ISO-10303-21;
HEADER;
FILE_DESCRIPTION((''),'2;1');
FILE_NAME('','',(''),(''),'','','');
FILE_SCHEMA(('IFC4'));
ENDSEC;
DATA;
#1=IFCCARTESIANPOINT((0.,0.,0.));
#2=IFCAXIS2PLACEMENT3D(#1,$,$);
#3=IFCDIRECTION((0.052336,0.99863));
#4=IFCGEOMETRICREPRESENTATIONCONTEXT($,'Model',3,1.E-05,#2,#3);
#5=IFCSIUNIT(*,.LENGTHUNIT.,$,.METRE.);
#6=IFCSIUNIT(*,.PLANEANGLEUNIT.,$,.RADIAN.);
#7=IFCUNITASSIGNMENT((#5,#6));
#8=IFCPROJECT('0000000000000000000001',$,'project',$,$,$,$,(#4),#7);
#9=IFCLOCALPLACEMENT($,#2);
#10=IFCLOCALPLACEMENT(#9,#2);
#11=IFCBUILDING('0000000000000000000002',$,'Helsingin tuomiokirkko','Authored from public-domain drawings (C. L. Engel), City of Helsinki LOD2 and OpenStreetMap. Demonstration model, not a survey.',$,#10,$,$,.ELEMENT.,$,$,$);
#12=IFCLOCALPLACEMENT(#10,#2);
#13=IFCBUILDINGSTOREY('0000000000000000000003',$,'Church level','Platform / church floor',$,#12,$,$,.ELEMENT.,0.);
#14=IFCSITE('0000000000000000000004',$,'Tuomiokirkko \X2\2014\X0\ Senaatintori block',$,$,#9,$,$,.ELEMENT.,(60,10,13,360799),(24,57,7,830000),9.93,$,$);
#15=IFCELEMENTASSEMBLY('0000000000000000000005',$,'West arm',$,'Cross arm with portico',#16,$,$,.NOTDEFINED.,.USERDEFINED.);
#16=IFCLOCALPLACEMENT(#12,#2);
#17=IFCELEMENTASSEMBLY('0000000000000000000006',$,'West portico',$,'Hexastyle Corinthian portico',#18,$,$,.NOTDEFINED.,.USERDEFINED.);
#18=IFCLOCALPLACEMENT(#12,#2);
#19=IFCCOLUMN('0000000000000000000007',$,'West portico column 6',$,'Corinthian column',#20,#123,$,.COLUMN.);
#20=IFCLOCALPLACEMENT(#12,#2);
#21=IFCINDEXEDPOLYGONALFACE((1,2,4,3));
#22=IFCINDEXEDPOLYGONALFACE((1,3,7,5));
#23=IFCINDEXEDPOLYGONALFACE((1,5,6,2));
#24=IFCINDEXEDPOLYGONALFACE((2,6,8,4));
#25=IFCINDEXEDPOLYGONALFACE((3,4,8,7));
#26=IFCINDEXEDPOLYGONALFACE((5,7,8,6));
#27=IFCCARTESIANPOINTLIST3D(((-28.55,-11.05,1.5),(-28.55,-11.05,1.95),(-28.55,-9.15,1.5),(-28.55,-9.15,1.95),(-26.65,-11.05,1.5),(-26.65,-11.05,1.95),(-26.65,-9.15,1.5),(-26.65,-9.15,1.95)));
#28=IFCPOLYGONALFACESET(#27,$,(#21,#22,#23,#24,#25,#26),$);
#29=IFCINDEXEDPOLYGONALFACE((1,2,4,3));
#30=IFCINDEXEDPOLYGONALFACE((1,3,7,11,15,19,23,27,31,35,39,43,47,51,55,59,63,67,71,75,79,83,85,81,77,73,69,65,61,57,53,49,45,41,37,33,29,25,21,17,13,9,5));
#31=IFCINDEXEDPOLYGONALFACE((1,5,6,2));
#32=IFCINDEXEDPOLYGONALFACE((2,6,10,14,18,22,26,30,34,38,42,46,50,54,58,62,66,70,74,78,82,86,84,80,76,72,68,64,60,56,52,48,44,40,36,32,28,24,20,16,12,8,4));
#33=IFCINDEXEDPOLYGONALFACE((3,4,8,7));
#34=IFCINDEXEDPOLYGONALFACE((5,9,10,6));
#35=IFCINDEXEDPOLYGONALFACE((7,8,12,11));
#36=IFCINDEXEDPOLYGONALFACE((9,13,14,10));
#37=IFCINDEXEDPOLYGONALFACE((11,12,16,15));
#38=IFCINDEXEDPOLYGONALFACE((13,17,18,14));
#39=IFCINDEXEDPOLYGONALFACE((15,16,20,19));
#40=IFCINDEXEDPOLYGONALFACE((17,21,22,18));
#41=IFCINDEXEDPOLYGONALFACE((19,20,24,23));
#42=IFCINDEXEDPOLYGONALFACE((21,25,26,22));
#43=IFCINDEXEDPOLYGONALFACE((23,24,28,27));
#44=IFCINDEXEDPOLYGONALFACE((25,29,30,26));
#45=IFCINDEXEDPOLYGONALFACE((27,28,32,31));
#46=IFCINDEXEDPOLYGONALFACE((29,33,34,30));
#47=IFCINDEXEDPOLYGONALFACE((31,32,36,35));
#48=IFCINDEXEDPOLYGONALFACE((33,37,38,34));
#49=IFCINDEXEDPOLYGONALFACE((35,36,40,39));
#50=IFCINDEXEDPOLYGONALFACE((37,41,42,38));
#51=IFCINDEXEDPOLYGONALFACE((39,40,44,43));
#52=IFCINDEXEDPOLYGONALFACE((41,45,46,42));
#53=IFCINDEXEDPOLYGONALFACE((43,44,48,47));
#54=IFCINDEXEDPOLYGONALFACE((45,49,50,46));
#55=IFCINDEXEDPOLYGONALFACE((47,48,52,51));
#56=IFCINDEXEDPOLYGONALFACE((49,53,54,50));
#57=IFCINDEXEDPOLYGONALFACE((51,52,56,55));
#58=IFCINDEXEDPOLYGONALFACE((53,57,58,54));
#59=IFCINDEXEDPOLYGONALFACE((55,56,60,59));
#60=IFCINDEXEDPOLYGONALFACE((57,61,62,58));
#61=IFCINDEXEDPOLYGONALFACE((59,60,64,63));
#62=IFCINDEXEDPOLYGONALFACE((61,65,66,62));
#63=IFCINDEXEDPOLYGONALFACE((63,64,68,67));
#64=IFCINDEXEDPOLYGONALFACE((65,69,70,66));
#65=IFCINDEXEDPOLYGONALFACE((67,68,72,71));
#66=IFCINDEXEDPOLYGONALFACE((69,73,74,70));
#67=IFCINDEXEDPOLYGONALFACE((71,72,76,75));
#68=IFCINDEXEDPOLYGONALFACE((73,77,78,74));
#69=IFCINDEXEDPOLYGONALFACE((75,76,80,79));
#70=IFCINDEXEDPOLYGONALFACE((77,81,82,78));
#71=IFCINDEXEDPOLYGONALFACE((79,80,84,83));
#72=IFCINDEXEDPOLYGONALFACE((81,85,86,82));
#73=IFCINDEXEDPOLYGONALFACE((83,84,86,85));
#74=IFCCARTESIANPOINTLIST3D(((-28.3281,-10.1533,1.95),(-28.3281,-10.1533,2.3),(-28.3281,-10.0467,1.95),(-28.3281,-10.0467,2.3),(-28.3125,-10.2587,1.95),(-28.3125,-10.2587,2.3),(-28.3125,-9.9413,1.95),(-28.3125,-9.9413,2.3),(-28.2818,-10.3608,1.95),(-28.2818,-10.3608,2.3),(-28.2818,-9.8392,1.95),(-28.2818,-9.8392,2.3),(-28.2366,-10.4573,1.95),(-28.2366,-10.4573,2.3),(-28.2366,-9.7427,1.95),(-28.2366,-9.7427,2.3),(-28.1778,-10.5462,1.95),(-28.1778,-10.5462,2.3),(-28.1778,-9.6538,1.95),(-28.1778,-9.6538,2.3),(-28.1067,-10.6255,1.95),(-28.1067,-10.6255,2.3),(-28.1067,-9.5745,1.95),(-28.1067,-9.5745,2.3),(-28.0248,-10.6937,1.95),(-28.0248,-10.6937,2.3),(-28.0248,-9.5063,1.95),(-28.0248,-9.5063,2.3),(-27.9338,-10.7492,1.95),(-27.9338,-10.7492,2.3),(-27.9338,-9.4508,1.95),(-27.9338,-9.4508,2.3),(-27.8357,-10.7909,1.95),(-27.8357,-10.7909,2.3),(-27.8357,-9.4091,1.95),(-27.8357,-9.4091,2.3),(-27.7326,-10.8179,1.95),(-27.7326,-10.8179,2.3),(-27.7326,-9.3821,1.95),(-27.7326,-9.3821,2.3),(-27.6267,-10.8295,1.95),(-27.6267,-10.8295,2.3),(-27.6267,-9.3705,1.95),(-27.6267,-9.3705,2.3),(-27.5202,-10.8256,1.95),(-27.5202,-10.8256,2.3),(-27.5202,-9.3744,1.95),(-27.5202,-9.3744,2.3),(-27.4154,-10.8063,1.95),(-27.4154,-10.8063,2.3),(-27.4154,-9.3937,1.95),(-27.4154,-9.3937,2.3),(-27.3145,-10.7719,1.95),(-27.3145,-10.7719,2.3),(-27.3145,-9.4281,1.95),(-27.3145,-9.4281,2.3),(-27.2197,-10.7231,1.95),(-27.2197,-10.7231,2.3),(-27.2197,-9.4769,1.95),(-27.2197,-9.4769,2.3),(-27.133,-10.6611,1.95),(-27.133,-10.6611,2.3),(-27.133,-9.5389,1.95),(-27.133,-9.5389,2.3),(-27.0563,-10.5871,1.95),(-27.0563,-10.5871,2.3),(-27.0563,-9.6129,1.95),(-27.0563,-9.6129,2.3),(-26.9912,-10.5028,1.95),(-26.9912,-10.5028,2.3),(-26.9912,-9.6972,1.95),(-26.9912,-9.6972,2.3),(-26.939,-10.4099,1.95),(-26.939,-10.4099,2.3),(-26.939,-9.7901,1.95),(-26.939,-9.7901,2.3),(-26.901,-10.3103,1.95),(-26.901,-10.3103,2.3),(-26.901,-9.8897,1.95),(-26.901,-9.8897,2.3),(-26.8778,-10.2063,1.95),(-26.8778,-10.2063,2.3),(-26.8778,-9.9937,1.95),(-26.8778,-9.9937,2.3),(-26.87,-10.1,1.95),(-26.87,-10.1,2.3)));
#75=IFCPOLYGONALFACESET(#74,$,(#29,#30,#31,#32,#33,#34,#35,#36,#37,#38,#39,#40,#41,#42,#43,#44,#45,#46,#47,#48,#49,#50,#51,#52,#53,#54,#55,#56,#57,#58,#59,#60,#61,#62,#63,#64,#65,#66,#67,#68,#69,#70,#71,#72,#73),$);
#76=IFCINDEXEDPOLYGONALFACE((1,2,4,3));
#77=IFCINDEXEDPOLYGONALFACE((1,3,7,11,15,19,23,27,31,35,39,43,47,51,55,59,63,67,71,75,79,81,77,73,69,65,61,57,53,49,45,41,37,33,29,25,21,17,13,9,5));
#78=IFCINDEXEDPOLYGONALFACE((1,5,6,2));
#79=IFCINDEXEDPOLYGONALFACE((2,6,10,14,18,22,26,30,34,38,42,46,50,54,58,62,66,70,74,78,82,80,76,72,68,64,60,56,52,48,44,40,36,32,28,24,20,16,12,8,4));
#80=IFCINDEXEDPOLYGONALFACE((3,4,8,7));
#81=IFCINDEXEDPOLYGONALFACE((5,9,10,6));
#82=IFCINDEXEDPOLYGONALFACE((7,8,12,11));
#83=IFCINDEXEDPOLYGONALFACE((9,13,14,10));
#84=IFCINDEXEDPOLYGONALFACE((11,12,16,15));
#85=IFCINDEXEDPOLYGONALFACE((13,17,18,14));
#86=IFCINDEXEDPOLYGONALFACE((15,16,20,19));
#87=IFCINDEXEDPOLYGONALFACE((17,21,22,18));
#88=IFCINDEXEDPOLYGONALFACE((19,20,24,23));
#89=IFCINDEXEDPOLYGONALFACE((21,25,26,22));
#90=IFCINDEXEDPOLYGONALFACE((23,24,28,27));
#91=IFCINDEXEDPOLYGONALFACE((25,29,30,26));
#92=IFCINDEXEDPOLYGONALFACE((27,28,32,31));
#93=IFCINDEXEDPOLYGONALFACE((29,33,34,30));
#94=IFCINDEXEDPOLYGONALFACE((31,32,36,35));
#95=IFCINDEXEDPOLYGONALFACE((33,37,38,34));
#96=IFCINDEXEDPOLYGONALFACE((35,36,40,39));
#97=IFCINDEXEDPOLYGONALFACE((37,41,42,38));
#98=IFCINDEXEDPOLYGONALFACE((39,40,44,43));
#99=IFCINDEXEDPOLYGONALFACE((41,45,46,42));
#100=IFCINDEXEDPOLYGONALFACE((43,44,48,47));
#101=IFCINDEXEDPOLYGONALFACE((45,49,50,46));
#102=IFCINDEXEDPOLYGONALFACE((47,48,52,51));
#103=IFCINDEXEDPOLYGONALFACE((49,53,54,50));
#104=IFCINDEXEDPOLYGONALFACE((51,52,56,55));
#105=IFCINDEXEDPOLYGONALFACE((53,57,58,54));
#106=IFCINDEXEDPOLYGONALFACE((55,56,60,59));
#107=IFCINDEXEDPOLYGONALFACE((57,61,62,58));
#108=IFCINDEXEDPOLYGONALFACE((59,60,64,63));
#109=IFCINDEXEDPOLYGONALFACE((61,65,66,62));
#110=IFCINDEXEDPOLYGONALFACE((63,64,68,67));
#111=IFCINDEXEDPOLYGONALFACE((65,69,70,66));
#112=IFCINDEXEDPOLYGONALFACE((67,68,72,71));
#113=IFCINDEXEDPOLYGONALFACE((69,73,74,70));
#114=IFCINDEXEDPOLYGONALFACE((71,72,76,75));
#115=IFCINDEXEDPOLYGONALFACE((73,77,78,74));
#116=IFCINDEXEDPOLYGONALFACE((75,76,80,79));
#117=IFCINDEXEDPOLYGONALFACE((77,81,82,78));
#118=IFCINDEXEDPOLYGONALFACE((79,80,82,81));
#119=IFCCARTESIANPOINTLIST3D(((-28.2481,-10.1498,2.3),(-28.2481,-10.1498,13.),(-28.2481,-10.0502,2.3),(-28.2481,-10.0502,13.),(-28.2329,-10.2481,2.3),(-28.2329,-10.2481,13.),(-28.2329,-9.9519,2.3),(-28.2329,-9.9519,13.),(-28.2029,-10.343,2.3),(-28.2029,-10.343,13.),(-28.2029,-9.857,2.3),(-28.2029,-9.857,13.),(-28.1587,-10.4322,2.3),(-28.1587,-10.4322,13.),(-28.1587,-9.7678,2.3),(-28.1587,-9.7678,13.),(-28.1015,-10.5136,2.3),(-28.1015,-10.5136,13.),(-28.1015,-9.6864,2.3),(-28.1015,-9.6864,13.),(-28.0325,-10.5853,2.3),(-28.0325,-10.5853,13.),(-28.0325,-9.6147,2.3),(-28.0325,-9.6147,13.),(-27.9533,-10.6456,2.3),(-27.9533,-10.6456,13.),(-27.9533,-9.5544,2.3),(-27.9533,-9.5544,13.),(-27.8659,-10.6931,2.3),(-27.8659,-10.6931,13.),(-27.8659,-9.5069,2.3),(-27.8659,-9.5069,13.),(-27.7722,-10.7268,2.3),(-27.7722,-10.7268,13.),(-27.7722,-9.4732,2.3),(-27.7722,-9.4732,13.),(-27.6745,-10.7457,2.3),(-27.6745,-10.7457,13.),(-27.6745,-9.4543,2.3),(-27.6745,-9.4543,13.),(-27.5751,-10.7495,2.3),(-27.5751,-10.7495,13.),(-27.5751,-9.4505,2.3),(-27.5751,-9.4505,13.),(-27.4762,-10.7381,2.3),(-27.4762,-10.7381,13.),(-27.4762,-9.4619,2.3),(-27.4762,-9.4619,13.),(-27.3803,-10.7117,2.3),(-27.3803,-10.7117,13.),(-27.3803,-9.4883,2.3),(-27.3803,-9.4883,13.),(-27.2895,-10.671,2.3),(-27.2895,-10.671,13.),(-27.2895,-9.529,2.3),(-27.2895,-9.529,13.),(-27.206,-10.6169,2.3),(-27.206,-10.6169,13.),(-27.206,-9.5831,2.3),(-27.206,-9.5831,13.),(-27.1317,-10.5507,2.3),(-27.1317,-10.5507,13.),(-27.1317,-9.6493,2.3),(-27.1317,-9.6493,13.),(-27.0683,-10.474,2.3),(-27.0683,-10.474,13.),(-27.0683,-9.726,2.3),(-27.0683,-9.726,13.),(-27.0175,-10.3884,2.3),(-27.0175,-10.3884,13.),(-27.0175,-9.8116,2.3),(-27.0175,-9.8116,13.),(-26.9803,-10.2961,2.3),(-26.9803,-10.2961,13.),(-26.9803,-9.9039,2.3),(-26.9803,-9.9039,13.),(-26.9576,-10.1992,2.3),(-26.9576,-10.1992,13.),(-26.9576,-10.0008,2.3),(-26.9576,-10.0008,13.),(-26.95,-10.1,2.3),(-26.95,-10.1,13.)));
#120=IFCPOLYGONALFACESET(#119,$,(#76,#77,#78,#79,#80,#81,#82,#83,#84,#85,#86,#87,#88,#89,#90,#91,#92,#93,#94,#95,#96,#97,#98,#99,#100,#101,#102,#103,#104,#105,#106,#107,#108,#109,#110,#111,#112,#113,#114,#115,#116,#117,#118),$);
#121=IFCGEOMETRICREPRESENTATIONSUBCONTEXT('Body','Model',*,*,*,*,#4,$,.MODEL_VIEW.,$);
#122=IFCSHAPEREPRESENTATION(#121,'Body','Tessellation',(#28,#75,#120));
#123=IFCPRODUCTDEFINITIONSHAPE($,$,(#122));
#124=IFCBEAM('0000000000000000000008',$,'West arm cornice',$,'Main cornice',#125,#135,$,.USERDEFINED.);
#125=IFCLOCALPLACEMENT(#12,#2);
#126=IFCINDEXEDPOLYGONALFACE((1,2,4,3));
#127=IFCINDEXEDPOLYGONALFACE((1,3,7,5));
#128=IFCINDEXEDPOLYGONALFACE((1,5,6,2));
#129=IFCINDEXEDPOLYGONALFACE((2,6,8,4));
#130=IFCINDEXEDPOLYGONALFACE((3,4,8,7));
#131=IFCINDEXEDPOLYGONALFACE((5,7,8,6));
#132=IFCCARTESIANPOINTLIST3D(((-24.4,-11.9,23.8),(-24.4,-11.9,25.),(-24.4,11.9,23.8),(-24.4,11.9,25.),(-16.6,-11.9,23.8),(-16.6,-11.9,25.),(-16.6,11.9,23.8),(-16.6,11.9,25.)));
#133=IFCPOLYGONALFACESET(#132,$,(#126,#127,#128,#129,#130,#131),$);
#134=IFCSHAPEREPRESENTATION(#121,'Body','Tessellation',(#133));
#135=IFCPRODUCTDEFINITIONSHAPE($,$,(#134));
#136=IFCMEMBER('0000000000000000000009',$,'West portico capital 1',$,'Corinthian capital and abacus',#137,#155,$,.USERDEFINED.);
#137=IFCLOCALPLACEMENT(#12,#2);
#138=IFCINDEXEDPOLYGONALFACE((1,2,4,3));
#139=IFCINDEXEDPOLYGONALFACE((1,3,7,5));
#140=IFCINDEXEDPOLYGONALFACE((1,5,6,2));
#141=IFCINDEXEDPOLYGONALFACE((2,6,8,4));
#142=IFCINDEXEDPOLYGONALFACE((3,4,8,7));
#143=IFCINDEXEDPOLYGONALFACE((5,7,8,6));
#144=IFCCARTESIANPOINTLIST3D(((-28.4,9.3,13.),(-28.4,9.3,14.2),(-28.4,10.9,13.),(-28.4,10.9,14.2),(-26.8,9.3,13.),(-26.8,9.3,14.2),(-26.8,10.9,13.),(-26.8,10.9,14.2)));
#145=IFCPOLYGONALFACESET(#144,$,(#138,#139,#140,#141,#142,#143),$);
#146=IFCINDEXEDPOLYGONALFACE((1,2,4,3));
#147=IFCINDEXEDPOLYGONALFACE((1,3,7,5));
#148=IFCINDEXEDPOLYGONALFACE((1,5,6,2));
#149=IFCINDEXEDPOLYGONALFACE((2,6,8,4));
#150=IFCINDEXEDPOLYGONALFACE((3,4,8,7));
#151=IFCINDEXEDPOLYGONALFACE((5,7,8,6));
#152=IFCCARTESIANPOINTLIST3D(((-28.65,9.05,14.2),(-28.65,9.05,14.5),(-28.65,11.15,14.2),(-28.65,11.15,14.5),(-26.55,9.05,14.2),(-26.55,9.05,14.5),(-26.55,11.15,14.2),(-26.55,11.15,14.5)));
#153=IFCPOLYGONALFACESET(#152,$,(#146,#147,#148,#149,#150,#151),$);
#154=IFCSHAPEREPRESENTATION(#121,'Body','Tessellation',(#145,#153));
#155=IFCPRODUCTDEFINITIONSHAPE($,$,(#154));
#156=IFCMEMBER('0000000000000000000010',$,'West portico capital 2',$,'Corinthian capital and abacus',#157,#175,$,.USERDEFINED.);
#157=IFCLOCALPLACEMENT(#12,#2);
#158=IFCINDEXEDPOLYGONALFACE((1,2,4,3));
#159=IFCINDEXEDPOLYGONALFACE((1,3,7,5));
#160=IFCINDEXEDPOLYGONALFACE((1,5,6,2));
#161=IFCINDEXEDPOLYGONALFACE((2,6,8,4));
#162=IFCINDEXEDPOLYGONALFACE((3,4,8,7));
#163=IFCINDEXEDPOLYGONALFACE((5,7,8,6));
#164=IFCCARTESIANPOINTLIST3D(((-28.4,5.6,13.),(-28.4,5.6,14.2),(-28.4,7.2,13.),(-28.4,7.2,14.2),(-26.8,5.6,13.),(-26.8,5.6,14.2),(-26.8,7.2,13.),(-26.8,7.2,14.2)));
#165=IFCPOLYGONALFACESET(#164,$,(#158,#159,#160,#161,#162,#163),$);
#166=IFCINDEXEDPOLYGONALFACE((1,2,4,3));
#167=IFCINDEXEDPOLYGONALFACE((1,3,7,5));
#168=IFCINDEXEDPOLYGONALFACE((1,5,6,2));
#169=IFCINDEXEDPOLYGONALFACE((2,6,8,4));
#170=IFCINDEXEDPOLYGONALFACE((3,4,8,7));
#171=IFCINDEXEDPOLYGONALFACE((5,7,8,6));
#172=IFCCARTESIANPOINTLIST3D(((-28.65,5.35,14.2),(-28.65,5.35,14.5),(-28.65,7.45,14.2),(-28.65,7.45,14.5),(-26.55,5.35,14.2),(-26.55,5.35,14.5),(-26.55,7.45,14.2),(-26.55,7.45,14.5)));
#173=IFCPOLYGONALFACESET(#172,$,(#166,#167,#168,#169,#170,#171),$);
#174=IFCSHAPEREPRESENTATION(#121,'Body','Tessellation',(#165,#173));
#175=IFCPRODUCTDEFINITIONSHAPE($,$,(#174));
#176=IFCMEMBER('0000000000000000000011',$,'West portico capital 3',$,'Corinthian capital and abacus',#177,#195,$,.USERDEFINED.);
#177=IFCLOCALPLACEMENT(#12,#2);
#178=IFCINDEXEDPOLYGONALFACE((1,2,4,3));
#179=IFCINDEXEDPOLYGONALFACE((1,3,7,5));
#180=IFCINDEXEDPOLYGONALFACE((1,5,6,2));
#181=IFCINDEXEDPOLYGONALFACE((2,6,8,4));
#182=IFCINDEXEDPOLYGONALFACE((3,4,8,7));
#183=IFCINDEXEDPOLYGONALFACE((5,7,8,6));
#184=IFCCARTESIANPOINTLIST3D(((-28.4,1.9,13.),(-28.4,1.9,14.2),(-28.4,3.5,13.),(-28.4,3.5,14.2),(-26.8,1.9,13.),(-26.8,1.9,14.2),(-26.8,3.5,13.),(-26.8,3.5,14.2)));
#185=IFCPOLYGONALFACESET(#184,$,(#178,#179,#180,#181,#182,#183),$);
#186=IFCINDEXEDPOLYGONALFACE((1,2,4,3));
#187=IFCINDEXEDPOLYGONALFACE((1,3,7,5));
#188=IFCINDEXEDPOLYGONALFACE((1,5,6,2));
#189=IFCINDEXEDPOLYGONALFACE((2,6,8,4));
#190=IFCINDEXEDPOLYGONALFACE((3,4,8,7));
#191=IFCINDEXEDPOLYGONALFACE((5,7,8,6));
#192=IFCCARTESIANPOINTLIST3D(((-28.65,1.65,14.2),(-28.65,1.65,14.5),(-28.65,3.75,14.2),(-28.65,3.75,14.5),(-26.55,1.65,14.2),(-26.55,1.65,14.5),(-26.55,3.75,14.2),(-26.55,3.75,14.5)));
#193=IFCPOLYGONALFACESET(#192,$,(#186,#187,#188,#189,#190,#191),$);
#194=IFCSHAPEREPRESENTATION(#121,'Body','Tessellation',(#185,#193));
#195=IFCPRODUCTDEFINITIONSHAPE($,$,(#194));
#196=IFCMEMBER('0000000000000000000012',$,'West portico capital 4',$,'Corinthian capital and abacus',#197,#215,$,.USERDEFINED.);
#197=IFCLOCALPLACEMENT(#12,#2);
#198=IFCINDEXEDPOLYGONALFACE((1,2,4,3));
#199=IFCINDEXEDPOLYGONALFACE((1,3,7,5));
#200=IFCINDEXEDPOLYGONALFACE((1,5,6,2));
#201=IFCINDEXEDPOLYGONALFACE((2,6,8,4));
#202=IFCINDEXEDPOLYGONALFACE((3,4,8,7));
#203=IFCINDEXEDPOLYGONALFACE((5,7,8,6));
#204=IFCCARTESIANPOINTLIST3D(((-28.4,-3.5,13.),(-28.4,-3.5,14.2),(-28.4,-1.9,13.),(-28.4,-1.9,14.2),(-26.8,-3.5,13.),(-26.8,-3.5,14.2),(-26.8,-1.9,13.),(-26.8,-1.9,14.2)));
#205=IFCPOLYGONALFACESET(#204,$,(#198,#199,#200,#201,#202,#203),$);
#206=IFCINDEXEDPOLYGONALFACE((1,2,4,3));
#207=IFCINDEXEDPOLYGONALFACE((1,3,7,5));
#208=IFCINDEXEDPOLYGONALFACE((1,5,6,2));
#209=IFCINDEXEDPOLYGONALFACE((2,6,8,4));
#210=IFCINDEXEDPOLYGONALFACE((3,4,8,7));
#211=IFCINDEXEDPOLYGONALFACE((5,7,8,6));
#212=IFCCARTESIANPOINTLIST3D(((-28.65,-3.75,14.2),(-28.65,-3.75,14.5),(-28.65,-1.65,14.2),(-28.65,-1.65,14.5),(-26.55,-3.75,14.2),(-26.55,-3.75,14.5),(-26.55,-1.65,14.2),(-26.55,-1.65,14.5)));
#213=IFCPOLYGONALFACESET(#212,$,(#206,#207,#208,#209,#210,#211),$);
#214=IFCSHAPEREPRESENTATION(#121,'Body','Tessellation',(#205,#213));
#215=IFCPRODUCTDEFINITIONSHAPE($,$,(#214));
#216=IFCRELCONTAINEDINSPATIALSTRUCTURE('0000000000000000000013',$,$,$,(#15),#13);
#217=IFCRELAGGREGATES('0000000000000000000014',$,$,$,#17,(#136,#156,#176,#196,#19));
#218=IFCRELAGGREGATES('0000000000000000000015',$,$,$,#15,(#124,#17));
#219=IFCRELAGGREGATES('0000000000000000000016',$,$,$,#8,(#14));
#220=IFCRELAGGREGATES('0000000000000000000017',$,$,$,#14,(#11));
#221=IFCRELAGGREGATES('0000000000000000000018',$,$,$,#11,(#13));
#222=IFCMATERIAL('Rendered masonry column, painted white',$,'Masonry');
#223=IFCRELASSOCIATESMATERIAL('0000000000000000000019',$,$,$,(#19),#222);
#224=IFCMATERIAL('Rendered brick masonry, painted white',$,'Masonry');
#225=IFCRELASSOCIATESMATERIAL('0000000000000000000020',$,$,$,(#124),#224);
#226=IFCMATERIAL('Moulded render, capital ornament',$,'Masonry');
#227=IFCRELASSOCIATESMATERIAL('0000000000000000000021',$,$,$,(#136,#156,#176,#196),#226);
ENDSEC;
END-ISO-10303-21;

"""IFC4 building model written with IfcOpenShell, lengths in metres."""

from ifc_helpers import new_model, si_unit, direction, frame, origin, origin_2d_with_axis, place, context, subcontext, project, spatial, rectangle, circle, extrude, material, element, aggregate, save


model = new_model("IFC4")

# Units and contexts
model_context = context("Model", 3, precision=1e-05, world=origin(), true_north=direction((0.052336, 0.99863)))
body_context = subcontext(model_context, "Body", "Model", "MODEL_VIEW")
ifc_project = project(units=[si_unit("LENGTHUNIT", "METRE"), si_unit("PLANEANGLEUNIT", "RADIAN")], contexts=[model_context])

# Site, building, storey
site_placement = place(None, origin())
site = spatial("IfcSite", under=ifc_project, at=site_placement, Name="Tuomiokirkko — Senaatintori block", CompositionType="ELEMENT", RefLatitude=(60, 10, 13, 360799), RefLongitude=(24, 57, 7, 830000), RefElevation=9.93)
building_placement = place(site_placement, origin())
building = spatial("IfcBuilding", under=site, at=building_placement, Name="Helsingin tuomiokirkko", Description="Authored from public-domain drawings (C. L. Engel), City of Helsinki LOD2 and OpenStreetMap. Demonstration model, not a survey.", CompositionType="ELEMENT")
storey_placement = place(building_placement, origin())
storey = spatial("IfcBuildingStorey", under=building, at=storey_placement, Name="Church level", Description="Platform / church floor", CompositionType="ELEMENT", Elevation=0.0)

# Element assemblies, column, beam, members
assembly_1_placement = place(building_placement, origin())
assembly_1 = element("IfcElementAssembly", 1, at=assembly_1_placement, inside=storey, Name="West arm", ObjectType="Cross arm with portico", AssemblyPlace="NOTDEFINED", PredefinedType="USERDEFINED")
ifc_material_1 = material(Name="Rendered brick masonry, painted white", Category="Masonry")
assembly_2_placement = place(building_placement, origin())
assembly_2 = element("IfcElementAssembly", 2, at=assembly_2_placement, Name="West portico", ObjectType="Hexastyle Corinthian portico", AssemblyPlace="NOTDEFINED", PredefinedType="USERDEFINED")
ifc_material_2 = material(Name="Rendered masonry column, painted white", Category="Masonry")
column_1_placement = place(building_placement, origin())
column_1 = element("IfcColumn", 3, at=column_1_placement, material=ifc_material_2, Name="West portico column 6", ObjectType="Corinthian column", PredefinedType="COLUMN", context=body_context, shape_type="SweptSolid", body=[
    extrude(rectangle(XDim=1.9, YDim=1.9, at=origin_2d_with_axis()), frame((-27.6, -10.1, 1.5)), (0.0, 0.0, 1.0), 0.45),
    extrude(circle(Radius=0.73, at=origin_2d_with_axis()), frame((-27.6, -10.1, 1.95)), (0.0, 0.0, 1.0), 0.35),
    extrude(circle(Radius=0.65, at=origin_2d_with_axis()), frame((-27.6, -10.1, 2.3)), (0.0, 0.0, 1.0), 10.7),
])
beam_1_placement = place(building_placement, origin())
beam_1 = element("IfcBeam", 4, at=beam_1_placement, material=ifc_material_1, Name="West arm cornice", ObjectType="Main cornice", PredefinedType="USERDEFINED", context=body_context, shape_type="SweptSolid", body=[
    extrude(rectangle(XDim=7.8, YDim=23.8, at=origin_2d_with_axis()), frame((-20.5, 0.0, 23.8)), (0.0, 0.0, 1.0), 1.2),
])
ifc_material_3 = material(Name="Moulded render, capital ornament", Category="Masonry")
member_1_placement = place(building_placement, origin())
member_1 = element("IfcMember", 5, at=member_1_placement, material=ifc_material_3, Name="West portico capital 1", ObjectType="Corinthian capital and abacus", PredefinedType="USERDEFINED", context=body_context, shape_type="SweptSolid", body=[
    extrude(rectangle(XDim=1.6, YDim=1.6, at=origin_2d_with_axis()), frame((-27.6, 10.1, 13.0)), (0.0, 0.0, 1.0), 1.2),
    extrude(rectangle(XDim=2.1, YDim=2.1, at=origin_2d_with_axis()), frame((-27.6, 10.1, 14.2)), (0.0, 0.0, 1.0), 0.3),
])
member_2_placement = place(building_placement, origin())
member_2 = element("IfcMember", 6, at=member_2_placement, material=ifc_material_3, Name="West portico capital 2", ObjectType="Corinthian capital and abacus", PredefinedType="USERDEFINED", context=body_context, shape_type="SweptSolid", body=[
    extrude(rectangle(XDim=1.6, YDim=1.6, at=origin_2d_with_axis()), frame((-27.6, 6.4, 13.0)), (0.0, 0.0, 1.0), 1.2),
    extrude(rectangle(XDim=2.1, YDim=2.1, at=origin_2d_with_axis()), frame((-27.6, 6.4, 14.2)), (0.0, 0.0, 1.0), 0.3),
])
member_3_placement = place(building_placement, origin())
member_3 = element("IfcMember", 7, at=member_3_placement, material=ifc_material_3, Name="West portico capital 3", ObjectType="Corinthian capital and abacus", PredefinedType="USERDEFINED", context=body_context, shape_type="SweptSolid", body=[
    extrude(rectangle(XDim=1.6, YDim=1.6, at=origin_2d_with_axis()), frame((-27.6, 2.7, 13.0)), (0.0, 0.0, 1.0), 1.2),
    extrude(rectangle(XDim=2.1, YDim=2.1, at=origin_2d_with_axis()), frame((-27.6, 2.7, 14.2)), (0.0, 0.0, 1.0), 0.3),
])
member_4_placement = place(building_placement, origin())
member_4 = element("IfcMember", 8, at=member_4_placement, material=ifc_material_3, Name="West portico capital 4", ObjectType="Corinthian capital and abacus", PredefinedType="USERDEFINED", context=body_context, shape_type="SweptSolid", body=[
    extrude(rectangle(XDim=1.6, YDim=1.6, at=origin_2d_with_axis()), frame((-27.6, -2.7, 13.0)), (0.0, 0.0, 1.0), 1.2),
    extrude(rectangle(XDim=2.1, YDim=2.1, at=origin_2d_with_axis()), frame((-27.6, -2.7, 14.2)), (0.0, 0.0, 1.0), 0.3),
])

aggregate(assembly_2, [member_1, member_2, member_3, member_4, column_1])

aggregate(assembly_1, [beam_1, assembly_2])

save(model, "model.ifc")
